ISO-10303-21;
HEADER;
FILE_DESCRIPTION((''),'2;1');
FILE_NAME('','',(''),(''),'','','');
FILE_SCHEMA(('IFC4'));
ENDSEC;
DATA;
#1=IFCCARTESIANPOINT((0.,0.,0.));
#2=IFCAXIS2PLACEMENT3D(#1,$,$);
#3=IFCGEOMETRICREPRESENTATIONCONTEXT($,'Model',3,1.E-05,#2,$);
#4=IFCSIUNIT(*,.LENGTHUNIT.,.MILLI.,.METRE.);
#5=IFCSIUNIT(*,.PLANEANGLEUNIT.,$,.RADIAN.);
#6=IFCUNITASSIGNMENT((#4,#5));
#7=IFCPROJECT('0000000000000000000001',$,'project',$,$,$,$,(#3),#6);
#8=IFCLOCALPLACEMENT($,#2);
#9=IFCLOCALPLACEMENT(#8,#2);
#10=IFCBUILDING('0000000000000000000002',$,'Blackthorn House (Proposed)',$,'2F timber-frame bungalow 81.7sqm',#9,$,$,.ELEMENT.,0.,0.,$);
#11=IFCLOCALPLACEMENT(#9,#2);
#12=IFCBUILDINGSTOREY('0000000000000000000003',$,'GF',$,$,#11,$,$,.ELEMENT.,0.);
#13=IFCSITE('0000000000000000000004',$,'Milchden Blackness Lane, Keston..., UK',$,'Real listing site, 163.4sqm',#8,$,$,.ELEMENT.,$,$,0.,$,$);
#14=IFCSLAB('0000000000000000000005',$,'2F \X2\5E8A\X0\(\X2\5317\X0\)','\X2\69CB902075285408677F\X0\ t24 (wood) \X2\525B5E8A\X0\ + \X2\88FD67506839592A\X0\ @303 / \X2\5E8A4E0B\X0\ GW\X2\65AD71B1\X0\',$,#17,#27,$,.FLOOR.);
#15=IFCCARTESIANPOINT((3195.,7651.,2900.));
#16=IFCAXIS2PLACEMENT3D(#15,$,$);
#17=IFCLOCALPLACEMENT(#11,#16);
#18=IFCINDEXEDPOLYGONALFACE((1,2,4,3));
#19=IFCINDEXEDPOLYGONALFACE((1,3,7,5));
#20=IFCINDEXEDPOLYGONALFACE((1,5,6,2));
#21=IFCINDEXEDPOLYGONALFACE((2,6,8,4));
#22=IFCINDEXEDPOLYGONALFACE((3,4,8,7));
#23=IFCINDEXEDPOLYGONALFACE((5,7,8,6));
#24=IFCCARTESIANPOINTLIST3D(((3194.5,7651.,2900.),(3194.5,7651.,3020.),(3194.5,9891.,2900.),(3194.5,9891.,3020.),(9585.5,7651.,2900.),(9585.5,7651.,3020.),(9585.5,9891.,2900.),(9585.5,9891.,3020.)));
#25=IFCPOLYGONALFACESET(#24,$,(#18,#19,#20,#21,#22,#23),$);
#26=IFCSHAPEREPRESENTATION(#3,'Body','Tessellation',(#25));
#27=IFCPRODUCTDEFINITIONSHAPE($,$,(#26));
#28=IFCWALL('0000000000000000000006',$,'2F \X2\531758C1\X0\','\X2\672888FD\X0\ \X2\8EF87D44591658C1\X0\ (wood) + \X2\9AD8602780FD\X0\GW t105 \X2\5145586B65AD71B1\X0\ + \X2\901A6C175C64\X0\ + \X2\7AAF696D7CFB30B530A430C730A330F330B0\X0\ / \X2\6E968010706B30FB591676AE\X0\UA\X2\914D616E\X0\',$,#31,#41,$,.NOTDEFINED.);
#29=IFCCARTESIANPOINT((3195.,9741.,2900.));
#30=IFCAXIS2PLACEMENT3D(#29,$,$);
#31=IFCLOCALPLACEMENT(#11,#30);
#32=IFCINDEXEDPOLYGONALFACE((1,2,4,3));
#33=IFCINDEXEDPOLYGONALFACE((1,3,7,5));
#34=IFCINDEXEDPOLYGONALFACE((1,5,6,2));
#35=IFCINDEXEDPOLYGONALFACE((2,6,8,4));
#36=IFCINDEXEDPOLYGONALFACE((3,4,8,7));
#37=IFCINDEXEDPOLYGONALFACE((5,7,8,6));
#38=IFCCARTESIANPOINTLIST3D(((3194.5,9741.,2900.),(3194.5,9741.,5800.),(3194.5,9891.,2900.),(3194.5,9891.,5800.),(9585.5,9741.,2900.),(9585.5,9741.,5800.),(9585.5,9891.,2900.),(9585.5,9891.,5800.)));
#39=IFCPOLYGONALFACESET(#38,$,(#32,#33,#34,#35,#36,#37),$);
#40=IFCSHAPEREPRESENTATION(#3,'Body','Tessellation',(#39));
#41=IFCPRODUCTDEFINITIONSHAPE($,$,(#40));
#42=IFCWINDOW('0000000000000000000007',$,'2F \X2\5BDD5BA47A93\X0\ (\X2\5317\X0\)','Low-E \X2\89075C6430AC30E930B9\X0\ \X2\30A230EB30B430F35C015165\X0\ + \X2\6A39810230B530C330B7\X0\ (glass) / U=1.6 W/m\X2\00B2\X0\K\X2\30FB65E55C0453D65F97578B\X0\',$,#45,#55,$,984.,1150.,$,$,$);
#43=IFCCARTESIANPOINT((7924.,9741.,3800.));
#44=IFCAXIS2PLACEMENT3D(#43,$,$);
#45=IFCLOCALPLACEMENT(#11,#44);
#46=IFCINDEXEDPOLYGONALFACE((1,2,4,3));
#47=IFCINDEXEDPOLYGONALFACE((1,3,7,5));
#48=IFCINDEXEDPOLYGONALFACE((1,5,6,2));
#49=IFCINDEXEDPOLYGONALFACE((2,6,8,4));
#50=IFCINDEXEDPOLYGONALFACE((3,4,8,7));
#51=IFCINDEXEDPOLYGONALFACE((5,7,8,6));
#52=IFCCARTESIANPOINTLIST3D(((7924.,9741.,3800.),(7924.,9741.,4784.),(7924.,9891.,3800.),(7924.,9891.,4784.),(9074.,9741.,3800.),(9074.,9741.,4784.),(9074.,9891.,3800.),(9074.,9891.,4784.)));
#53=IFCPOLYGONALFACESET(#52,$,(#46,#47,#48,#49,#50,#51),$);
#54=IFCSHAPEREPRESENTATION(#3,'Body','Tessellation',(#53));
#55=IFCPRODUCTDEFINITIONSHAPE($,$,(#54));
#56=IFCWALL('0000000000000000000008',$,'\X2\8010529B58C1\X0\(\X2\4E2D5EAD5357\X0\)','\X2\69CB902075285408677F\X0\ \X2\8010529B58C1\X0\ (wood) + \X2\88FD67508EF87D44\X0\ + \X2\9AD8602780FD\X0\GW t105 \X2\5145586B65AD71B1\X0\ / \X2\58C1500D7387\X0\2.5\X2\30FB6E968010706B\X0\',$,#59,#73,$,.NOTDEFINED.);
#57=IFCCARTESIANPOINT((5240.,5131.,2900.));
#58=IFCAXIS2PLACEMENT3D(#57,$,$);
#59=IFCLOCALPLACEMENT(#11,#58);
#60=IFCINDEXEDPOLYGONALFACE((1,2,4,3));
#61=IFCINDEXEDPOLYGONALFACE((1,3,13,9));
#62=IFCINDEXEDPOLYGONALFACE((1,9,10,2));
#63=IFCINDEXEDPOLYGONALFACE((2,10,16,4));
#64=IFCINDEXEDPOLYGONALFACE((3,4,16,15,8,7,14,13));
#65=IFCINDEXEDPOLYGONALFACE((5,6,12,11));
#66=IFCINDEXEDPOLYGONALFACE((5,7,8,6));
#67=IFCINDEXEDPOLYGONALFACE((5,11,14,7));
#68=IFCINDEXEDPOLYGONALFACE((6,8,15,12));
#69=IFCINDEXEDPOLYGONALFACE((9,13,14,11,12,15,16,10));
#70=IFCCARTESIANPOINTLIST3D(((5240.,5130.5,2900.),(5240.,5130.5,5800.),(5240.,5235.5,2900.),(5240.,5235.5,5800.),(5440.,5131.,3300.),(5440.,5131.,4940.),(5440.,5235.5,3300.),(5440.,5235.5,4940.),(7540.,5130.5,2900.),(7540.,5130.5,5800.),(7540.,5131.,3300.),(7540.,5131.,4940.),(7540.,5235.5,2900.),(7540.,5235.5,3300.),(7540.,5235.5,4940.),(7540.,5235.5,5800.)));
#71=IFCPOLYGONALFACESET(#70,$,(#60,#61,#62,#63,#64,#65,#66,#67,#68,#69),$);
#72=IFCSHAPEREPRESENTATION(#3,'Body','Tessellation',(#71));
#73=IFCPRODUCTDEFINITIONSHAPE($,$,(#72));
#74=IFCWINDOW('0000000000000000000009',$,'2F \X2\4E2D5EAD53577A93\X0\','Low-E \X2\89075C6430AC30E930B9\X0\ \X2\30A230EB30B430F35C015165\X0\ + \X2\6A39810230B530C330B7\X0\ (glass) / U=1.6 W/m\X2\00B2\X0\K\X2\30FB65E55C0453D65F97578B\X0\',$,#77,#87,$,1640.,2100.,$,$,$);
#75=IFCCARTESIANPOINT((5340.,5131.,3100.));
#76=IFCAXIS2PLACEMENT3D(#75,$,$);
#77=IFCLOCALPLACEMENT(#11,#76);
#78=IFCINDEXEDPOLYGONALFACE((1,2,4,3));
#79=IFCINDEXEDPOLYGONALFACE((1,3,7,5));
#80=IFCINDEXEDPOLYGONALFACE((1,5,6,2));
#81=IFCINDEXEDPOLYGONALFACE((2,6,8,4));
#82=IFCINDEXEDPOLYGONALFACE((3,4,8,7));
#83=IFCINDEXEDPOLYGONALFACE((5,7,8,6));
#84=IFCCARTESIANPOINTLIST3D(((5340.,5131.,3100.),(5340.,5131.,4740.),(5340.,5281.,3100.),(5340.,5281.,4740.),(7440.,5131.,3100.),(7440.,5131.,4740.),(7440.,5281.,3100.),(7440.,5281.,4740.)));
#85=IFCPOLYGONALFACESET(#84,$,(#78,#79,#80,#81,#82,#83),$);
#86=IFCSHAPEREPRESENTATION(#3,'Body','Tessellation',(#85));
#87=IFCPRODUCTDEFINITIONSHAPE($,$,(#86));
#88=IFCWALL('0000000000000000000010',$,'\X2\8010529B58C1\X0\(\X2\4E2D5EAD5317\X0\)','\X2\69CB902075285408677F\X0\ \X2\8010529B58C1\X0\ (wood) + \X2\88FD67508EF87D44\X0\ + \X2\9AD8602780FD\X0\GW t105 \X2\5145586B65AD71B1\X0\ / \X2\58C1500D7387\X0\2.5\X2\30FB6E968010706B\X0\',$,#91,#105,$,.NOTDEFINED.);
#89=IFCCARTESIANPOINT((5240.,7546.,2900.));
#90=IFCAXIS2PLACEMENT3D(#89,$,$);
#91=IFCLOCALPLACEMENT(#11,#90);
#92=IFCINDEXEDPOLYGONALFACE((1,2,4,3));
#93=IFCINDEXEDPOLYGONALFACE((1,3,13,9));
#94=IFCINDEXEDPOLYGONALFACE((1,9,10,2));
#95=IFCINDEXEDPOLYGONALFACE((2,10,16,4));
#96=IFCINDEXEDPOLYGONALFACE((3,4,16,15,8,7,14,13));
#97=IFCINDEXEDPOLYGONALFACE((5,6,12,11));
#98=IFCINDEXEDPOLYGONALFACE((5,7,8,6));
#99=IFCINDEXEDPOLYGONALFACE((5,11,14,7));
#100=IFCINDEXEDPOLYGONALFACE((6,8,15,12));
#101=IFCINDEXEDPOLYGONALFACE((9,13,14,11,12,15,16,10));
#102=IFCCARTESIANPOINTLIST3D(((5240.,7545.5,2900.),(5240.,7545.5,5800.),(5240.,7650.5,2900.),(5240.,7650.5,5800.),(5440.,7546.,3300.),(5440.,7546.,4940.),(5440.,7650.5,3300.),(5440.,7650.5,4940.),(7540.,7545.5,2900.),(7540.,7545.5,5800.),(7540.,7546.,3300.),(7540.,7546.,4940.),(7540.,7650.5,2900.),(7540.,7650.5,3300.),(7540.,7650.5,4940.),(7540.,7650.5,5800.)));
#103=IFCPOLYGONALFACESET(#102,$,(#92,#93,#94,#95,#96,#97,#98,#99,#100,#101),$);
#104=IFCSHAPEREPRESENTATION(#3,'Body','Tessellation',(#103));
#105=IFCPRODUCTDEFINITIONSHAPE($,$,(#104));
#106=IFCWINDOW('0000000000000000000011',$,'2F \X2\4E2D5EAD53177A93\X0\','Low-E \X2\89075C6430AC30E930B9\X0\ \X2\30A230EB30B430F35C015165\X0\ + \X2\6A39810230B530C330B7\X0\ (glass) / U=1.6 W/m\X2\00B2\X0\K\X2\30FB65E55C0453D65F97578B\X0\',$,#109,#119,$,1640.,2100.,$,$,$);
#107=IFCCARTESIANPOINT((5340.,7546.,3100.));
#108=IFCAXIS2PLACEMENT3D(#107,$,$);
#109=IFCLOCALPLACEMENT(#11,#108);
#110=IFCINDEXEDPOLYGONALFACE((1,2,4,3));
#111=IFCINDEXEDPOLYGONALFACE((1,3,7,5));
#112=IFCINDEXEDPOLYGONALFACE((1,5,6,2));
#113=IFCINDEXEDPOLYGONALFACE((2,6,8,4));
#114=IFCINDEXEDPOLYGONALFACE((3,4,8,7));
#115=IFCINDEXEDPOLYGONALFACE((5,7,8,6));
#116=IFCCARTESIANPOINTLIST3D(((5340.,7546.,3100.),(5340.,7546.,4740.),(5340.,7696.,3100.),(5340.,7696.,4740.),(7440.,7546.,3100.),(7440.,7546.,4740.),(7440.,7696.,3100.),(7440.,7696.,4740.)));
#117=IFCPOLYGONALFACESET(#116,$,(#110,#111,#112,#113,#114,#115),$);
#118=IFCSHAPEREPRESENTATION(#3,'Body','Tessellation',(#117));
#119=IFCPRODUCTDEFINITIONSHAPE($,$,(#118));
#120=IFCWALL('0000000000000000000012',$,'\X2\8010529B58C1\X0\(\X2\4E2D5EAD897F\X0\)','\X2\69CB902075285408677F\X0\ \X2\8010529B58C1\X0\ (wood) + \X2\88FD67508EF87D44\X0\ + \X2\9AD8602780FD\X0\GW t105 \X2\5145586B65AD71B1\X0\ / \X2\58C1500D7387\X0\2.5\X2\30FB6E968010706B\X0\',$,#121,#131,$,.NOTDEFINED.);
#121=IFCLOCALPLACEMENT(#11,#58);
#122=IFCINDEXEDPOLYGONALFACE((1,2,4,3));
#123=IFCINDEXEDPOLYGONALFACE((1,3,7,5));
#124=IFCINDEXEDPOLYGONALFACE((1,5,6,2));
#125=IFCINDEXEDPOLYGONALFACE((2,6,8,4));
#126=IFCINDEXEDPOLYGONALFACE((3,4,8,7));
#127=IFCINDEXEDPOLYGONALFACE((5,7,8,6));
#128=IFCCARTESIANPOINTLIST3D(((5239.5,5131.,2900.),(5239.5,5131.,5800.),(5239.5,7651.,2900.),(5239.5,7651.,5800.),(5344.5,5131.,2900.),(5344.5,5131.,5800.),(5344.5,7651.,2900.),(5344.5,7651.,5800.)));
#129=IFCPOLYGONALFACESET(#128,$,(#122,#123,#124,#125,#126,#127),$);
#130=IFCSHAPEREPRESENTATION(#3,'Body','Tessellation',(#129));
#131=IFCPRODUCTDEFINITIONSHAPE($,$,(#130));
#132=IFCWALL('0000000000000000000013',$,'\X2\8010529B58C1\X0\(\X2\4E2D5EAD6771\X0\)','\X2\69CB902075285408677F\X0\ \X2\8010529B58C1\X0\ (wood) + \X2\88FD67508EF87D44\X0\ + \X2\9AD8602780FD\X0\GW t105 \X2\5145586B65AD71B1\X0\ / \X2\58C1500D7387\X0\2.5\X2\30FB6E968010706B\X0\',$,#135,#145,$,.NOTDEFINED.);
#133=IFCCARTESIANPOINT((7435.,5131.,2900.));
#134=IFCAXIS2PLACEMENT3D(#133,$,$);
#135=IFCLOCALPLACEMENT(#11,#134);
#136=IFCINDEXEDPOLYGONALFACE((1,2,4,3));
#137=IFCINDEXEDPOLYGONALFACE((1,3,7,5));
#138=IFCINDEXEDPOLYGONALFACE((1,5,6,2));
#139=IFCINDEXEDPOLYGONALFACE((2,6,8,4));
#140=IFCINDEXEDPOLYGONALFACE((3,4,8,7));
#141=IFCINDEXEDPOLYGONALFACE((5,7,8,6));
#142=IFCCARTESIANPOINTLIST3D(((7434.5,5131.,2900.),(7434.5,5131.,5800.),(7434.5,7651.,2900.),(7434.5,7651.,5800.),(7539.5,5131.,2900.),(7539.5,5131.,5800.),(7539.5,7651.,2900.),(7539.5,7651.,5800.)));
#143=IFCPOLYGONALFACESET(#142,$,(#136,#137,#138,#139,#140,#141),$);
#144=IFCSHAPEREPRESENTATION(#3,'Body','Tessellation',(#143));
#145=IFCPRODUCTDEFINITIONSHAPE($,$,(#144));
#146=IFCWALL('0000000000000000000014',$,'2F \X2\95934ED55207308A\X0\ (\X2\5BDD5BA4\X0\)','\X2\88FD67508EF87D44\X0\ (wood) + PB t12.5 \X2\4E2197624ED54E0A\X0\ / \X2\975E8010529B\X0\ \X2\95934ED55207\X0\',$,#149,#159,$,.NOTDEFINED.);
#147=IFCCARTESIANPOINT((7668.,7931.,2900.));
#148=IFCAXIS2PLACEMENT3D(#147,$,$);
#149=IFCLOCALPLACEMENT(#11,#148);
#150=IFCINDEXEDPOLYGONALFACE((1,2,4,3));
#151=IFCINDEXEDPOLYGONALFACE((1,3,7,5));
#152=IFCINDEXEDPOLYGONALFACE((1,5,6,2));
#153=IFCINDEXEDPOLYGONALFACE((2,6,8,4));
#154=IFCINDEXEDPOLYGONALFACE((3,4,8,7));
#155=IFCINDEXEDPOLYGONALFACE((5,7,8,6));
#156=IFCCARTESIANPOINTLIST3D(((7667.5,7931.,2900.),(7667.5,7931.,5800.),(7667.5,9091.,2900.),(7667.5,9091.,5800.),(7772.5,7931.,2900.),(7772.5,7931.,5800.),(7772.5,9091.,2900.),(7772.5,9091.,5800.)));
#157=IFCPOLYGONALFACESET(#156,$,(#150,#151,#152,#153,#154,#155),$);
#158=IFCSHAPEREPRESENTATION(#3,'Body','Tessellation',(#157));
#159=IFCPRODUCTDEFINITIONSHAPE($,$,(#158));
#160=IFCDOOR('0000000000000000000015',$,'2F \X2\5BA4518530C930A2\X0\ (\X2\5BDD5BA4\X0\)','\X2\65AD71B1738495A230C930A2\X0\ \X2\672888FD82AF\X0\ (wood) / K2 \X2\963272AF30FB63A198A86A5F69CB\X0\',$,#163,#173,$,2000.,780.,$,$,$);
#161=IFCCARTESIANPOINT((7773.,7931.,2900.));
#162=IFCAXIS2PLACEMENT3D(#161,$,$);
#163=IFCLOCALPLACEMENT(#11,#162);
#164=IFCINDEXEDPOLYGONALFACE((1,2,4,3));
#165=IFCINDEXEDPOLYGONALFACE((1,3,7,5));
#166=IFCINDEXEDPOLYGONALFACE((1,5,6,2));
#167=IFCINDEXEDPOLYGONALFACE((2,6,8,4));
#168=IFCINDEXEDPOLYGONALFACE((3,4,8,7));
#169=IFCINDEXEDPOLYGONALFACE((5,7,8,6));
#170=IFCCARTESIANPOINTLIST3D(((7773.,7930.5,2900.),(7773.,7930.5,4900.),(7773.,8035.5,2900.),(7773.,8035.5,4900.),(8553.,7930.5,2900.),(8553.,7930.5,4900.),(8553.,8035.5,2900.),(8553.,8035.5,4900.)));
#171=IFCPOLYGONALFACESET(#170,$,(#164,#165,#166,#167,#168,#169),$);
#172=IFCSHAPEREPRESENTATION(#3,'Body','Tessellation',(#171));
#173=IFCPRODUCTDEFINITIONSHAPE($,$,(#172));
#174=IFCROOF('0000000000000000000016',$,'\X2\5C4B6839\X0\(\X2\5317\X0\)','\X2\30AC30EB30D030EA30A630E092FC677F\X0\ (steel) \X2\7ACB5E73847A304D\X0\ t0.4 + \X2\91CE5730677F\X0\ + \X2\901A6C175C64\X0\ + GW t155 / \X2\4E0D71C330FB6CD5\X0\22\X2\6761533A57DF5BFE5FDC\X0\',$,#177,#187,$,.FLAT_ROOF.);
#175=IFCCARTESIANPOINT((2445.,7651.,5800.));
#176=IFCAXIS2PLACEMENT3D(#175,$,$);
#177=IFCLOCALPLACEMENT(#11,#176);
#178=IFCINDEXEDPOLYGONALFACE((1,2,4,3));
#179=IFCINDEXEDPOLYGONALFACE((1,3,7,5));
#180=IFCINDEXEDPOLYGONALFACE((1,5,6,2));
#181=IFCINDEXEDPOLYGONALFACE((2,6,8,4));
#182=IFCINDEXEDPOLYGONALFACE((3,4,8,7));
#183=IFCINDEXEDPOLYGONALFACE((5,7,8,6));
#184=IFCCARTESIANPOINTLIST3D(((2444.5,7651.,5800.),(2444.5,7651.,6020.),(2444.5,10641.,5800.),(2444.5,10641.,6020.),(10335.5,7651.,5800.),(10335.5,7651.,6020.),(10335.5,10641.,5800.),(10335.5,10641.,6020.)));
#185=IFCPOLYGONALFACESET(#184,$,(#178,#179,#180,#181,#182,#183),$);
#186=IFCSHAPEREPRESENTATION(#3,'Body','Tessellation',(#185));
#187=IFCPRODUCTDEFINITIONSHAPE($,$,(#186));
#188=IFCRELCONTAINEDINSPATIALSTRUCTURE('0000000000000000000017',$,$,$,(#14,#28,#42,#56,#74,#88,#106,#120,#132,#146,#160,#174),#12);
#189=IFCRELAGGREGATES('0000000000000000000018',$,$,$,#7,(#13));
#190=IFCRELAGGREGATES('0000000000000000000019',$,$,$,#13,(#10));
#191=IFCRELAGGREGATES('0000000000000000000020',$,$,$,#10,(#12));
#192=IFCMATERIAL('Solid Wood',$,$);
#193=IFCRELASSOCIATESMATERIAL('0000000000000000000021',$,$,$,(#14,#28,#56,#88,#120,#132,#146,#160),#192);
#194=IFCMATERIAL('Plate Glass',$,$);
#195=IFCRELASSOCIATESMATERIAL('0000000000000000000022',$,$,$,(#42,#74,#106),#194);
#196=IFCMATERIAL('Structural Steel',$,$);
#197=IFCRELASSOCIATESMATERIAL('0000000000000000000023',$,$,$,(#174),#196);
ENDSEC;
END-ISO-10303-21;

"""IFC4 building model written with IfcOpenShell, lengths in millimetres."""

from ifc_helpers import new_model, si_unit, frame, frame_2d, origin, place, context, project, spatial, rectangle, extrude, material, element, fill, save


model = new_model("IFC4")

# Units and contexts
model_context = context("Model", 3, precision=1e-05, world=origin())
ifc_project = project(units=[si_unit("LENGTHUNIT", "METRE", prefix="MILLI"), si_unit("PLANEANGLEUNIT", "RADIAN")], contexts=[model_context])

# Site, building, storey
site_placement = place(None, origin())
site = spatial("IfcSite", under=ifc_project, at=site_placement, Name="Milchden Blackness Lane, Keston..., UK", ObjectType="Real listing site, 163.4sqm", CompositionType="ELEMENT", RefElevation=0.0)
building_placement = place(site_placement, origin())
building = spatial("IfcBuilding", under=site, at=building_placement, Name="Blackthorn House (Proposed)", ObjectType="2F timber-frame bungalow 81.7sqm", CompositionType="ELEMENT", ElevationOfRefHeight=0.0, ElevationOfTerrain=0.0)
storey_placement = place(building_placement, origin())
storey = spatial("IfcBuildingStorey", under=building, at=storey_placement, Name="GF", CompositionType="ELEMENT", Elevation=0.0)

# Slab
ifc_material_1 = material(Name="Solid Wood")
slab_placement = place(storey_placement, frame((3195.0, 7651.0, 2900.0)))
element("IfcSlab", 1, at=slab_placement, inside=storey, material=ifc_material_1, Name="2F 床(北)", Description="構造用合板 t24 (wood) 剛床 + 製材根太 @303 / 床下 GW断熱", PredefinedType="FLOOR", context=model_context, shape_type="SweptSolid", body=[
    extrude(rectangle(XDim=6391.0, YDim=2240.0, at=frame_2d((3195.0, 1120.0))), frame((3195.0, 7651.0, 2900.0)), (0.0, 0.0, 1.0), 120.0),
])

# Walls, openings, windows
wall_1_placement = place(storey_placement, frame((3195.0, 9741.0, 2900.0)))
wall_1 = element("IfcWall", 2, at=wall_1_placement, inside=storey, material=ifc_material_1, Name="2F 北壁", Description="木製 軸組外壁 (wood) + 高性能GW t105 充填断熱 + 通気層 + 窯業系サイディング / 準耐火・外皮UA配慮", PredefinedType="NOTDEFINED", context=model_context, shape_type="SweptSolid", body=[
    extrude(rectangle(XDim=6391.0, YDim=150.0, at=frame_2d((3195.0, 75.0))), frame((3195.0, 9741.0, 2900.0)), (0.0, 0.0, 1.0), 2900.0),
])
opening_1_placement = place(storey_placement, frame((7924.0, 9741.0, 3800.0)))
opening_1 = element("IfcOpeningElement", 3, at=opening_1_placement, cuts=wall_1, PredefinedType="NOTDEFINED", context=model_context, shape_type="SweptSolid", body=[
    extrude(rectangle(XDim=1150.0, YDim=150.0, at=frame_2d((575.0, 75.0))), frame((7924.0, 9741.0, 3800.0)), (0.0, 0.0, 1.0), 984.0),
])
ifc_material_2 = material(Name="Plate Glass")
window_1_placement = place(storey_placement, frame((7924.0, 9741.0, 3800.0)))
window_1 = element("IfcWindow", 4, at=window_1_placement, inside=storey, material=ifc_material_2, Name="2F 寝室窓 (北)", Description="Low-E 複層ガラス アルゴン封入 + 樹脂サッシ (glass) / U=1.6 W/m²K・日射取得型", OverallHeight=984.0, OverallWidth=1150.0, context=model_context, shape_type="SweptSolid", body=[
    extrude(rectangle(XDim=1150.0, YDim=150.0, at=frame_2d((575.0, 75.0))), frame((7924.0, 9741.0, 3800.0)), (0.0, 0.0, 1.0), 984.0),
])
fill(opening_1, window_1)
wall_2_placement = place(storey_placement, frame((5240.0, 5131.0, 2900.0)))
wall_2 = element("IfcWall", 5, at=wall_2_placement, inside=storey, material=ifc_material_1, Name="耐力壁(中庭南)", Description="構造用合板 耐力壁 (wood) + 製材軸組 + 高性能GW t105 充填断熱 / 壁倍率2.5・準耐火", PredefinedType="NOTDEFINED", context=model_context, shape_type="SweptSolid", body=[
    extrude(rectangle(XDim=2300.0, YDim=105.0, at=frame_2d((1150.0, 52.0))), frame((5240.0, 5131.0, 2900.0)), (0.0, 0.0, 1.0), 2900.0),
])
opening_2_placement = place(storey_placement, frame((5340.0, 5131.0, 3100.0)))
opening_2 = element("IfcOpeningElement", 6, at=opening_2_placement, cuts=wall_2, PredefinedType="NOTDEFINED", context=model_context, shape_type="SweptSolid", body=[
    extrude(rectangle(XDim=2100.0, YDim=150.0, at=frame_2d((1050.0, 75.0))), frame((5340.0, 5131.0, 3100.0)), (0.0, 0.0, 1.0), 1640.0),
])
window_2_placement = place(storey_placement, frame((5340.0, 5131.0, 3100.0)))
window_2 = element("IfcWindow", 7, at=window_2_placement, inside=storey, material=ifc_material_2, Name="2F 中庭南窓", Description="Low-E 複層ガラス アルゴン封入 + 樹脂サッシ (glass) / U=1.6 W/m²K・日射取得型", OverallHeight=1640.0, OverallWidth=2100.0, context=model_context, shape_type="SweptSolid", body=[
    extrude(rectangle(XDim=2100.0, YDim=150.0, at=frame_2d((1050.0, 75.0))), frame((5340.0, 5131.0, 3100.0)), (0.0, 0.0, 1.0), 1640.0),
])
fill(opening_2, window_2)
wall_3_placement = place(storey_placement, frame((5240.0, 7546.0, 2900.0)))
wall_3 = element("IfcWall", 8, at=wall_3_placement, inside=storey, material=ifc_material_1, Name="耐力壁(中庭北)", Description="構造用合板 耐力壁 (wood) + 製材軸組 + 高性能GW t105 充填断熱 / 壁倍率2.5・準耐火", PredefinedType="NOTDEFINED", context=model_context, shape_type="SweptSolid", body=[
    extrude(rectangle(XDim=2300.0, YDim=105.0, at=frame_2d((1150.0, 52.0))), frame((5240.0, 7546.0, 2900.0)), (0.0, 0.0, 1.0), 2900.0),
])
opening_3_placement = place(storey_placement, frame((5340.0, 7546.0, 3100.0)))
opening_3 = element("IfcOpeningElement", 9, at=opening_3_placement, cuts=wall_3, PredefinedType="NOTDEFINED", context=model_context, shape_type="SweptSolid", body=[
    extrude(rectangle(XDim=2100.0, YDim=150.0, at=frame_2d((1050.0, 75.0))), frame((5340.0, 7546.0, 3100.0)), (0.0, 0.0, 1.0), 1640.0),
])
window_3_placement = place(storey_placement, frame((5340.0, 7546.0, 3100.0)))
window_3 = element("IfcWindow", 10, at=window_3_placement, inside=storey, material=ifc_material_2, Name="2F 中庭北窓", Description="Low-E 複層ガラス アルゴン封入 + 樹脂サッシ (glass) / U=1.6 W/m²K・日射取得型", OverallHeight=1640.0, OverallWidth=2100.0, context=model_context, shape_type="SweptSolid", body=[
    extrude(rectangle(XDim=2100.0, YDim=150.0, at=frame_2d((1050.0, 75.0))), frame((5340.0, 7546.0, 3100.0)), (0.0, 0.0, 1.0), 1640.0),
])
fill(opening_3, window_3)

# Walls
wall_4_placement = place(storey_placement, frame((5240.0, 5131.0, 2900.0)))
element("IfcWall", 11, at=wall_4_placement, inside=storey, material=ifc_material_1, Name="耐力壁(中庭西)", Description="構造用合板 耐力壁 (wood) + 製材軸組 + 高性能GW t105 充填断熱 / 壁倍率2.5・準耐火", PredefinedType="NOTDEFINED", context=model_context, shape_type="SweptSolid", body=[
    extrude(rectangle(XDim=105.0, YDim=2520.0, at=frame_2d((52.0, 1260.0))), frame((5240.0, 5131.0, 2900.0)), (0.0, 0.0, 1.0), 2900.0),
])
wall_5_placement = place(storey_placement, frame((7435.0, 5131.0, 2900.0)))
element("IfcWall", 12, at=wall_5_placement, inside=storey, material=ifc_material_1, Name="耐力壁(中庭東)", Description="構造用合板 耐力壁 (wood) + 製材軸組 + 高性能GW t105 充填断熱 / 壁倍率2.5・準耐火", PredefinedType="NOTDEFINED", context=model_context, shape_type="SweptSolid", body=[
    extrude(rectangle(XDim=105.0, YDim=2520.0, at=frame_2d((52.0, 1260.0))), frame((7435.0, 5131.0, 2900.0)), (0.0, 0.0, 1.0), 2900.0),
])
wall_6_placement = place(storey_placement, frame((7668.0, 7931.0, 2900.0)))
element("IfcWall", 13, at=wall_6_placement, inside=storey, material=ifc_material_1, Name="2F 間仕切り (寝室)", Description="製材軸組 (wood) + PB t12.5 両面仕上 / 非耐力 間仕切", PredefinedType="NOTDEFINED", context=model_context, shape_type="SweptSolid", body=[
    extrude(rectangle(XDim=105.0, YDim=1160.0, at=frame_2d((52.0, 580.0))), frame((7668.0, 7931.0, 2900.0)), (0.0, 0.0, 1.0), 2900.0),
])

# Door
door_placement = place(storey_placement, frame((7773.0, 7931.0, 2900.0)))
element("IfcDoor", 14, at=door_placement, inside=storey, material=ifc_material_1, Name="2F 室内ドア (寝室)", Description="断熱玄関ドア 木製芯 (wood) / K2 防犯・採風機構", OverallHeight=2000.0, OverallWidth=780.0, context=model_context, shape_type="SweptSolid", body=[
    extrude(rectangle(XDim=780.0, YDim=105.0, at=frame_2d((390.0, 52.0))), frame((7773.0, 7931.0, 2900.0)), (0.0, 0.0, 1.0), 2000.0),
])

# Roof
ifc_material_3 = material(Name="Structural Steel")
for number, where, name in (
    (15, (2445.0, 7651.0, 5800.0), "屋根(北)"),
):
    element("IfcRoof", number, at=place(storey_placement, frame(where)), inside=storey, material=ifc_material_3, Name=name, Description="ガルバリウム鋼板 (steel) 立平葺き t0.4 + 野地板 + 通気層 + GW t155 / 不燃・法22条区域対応", PredefinedType="FLAT_ROOF", context=model_context, shape_type="SweptSolid", body=[
        extrude(rectangle(XDim=7891.0, YDim=2990.0, at=frame_2d((3945.0, 1495.0))), frame((2445.0, 7651.0, 5800.0)), (0.0, 0.0, 1.0), 220.0),
    ])

save(model, "model.ifc")
